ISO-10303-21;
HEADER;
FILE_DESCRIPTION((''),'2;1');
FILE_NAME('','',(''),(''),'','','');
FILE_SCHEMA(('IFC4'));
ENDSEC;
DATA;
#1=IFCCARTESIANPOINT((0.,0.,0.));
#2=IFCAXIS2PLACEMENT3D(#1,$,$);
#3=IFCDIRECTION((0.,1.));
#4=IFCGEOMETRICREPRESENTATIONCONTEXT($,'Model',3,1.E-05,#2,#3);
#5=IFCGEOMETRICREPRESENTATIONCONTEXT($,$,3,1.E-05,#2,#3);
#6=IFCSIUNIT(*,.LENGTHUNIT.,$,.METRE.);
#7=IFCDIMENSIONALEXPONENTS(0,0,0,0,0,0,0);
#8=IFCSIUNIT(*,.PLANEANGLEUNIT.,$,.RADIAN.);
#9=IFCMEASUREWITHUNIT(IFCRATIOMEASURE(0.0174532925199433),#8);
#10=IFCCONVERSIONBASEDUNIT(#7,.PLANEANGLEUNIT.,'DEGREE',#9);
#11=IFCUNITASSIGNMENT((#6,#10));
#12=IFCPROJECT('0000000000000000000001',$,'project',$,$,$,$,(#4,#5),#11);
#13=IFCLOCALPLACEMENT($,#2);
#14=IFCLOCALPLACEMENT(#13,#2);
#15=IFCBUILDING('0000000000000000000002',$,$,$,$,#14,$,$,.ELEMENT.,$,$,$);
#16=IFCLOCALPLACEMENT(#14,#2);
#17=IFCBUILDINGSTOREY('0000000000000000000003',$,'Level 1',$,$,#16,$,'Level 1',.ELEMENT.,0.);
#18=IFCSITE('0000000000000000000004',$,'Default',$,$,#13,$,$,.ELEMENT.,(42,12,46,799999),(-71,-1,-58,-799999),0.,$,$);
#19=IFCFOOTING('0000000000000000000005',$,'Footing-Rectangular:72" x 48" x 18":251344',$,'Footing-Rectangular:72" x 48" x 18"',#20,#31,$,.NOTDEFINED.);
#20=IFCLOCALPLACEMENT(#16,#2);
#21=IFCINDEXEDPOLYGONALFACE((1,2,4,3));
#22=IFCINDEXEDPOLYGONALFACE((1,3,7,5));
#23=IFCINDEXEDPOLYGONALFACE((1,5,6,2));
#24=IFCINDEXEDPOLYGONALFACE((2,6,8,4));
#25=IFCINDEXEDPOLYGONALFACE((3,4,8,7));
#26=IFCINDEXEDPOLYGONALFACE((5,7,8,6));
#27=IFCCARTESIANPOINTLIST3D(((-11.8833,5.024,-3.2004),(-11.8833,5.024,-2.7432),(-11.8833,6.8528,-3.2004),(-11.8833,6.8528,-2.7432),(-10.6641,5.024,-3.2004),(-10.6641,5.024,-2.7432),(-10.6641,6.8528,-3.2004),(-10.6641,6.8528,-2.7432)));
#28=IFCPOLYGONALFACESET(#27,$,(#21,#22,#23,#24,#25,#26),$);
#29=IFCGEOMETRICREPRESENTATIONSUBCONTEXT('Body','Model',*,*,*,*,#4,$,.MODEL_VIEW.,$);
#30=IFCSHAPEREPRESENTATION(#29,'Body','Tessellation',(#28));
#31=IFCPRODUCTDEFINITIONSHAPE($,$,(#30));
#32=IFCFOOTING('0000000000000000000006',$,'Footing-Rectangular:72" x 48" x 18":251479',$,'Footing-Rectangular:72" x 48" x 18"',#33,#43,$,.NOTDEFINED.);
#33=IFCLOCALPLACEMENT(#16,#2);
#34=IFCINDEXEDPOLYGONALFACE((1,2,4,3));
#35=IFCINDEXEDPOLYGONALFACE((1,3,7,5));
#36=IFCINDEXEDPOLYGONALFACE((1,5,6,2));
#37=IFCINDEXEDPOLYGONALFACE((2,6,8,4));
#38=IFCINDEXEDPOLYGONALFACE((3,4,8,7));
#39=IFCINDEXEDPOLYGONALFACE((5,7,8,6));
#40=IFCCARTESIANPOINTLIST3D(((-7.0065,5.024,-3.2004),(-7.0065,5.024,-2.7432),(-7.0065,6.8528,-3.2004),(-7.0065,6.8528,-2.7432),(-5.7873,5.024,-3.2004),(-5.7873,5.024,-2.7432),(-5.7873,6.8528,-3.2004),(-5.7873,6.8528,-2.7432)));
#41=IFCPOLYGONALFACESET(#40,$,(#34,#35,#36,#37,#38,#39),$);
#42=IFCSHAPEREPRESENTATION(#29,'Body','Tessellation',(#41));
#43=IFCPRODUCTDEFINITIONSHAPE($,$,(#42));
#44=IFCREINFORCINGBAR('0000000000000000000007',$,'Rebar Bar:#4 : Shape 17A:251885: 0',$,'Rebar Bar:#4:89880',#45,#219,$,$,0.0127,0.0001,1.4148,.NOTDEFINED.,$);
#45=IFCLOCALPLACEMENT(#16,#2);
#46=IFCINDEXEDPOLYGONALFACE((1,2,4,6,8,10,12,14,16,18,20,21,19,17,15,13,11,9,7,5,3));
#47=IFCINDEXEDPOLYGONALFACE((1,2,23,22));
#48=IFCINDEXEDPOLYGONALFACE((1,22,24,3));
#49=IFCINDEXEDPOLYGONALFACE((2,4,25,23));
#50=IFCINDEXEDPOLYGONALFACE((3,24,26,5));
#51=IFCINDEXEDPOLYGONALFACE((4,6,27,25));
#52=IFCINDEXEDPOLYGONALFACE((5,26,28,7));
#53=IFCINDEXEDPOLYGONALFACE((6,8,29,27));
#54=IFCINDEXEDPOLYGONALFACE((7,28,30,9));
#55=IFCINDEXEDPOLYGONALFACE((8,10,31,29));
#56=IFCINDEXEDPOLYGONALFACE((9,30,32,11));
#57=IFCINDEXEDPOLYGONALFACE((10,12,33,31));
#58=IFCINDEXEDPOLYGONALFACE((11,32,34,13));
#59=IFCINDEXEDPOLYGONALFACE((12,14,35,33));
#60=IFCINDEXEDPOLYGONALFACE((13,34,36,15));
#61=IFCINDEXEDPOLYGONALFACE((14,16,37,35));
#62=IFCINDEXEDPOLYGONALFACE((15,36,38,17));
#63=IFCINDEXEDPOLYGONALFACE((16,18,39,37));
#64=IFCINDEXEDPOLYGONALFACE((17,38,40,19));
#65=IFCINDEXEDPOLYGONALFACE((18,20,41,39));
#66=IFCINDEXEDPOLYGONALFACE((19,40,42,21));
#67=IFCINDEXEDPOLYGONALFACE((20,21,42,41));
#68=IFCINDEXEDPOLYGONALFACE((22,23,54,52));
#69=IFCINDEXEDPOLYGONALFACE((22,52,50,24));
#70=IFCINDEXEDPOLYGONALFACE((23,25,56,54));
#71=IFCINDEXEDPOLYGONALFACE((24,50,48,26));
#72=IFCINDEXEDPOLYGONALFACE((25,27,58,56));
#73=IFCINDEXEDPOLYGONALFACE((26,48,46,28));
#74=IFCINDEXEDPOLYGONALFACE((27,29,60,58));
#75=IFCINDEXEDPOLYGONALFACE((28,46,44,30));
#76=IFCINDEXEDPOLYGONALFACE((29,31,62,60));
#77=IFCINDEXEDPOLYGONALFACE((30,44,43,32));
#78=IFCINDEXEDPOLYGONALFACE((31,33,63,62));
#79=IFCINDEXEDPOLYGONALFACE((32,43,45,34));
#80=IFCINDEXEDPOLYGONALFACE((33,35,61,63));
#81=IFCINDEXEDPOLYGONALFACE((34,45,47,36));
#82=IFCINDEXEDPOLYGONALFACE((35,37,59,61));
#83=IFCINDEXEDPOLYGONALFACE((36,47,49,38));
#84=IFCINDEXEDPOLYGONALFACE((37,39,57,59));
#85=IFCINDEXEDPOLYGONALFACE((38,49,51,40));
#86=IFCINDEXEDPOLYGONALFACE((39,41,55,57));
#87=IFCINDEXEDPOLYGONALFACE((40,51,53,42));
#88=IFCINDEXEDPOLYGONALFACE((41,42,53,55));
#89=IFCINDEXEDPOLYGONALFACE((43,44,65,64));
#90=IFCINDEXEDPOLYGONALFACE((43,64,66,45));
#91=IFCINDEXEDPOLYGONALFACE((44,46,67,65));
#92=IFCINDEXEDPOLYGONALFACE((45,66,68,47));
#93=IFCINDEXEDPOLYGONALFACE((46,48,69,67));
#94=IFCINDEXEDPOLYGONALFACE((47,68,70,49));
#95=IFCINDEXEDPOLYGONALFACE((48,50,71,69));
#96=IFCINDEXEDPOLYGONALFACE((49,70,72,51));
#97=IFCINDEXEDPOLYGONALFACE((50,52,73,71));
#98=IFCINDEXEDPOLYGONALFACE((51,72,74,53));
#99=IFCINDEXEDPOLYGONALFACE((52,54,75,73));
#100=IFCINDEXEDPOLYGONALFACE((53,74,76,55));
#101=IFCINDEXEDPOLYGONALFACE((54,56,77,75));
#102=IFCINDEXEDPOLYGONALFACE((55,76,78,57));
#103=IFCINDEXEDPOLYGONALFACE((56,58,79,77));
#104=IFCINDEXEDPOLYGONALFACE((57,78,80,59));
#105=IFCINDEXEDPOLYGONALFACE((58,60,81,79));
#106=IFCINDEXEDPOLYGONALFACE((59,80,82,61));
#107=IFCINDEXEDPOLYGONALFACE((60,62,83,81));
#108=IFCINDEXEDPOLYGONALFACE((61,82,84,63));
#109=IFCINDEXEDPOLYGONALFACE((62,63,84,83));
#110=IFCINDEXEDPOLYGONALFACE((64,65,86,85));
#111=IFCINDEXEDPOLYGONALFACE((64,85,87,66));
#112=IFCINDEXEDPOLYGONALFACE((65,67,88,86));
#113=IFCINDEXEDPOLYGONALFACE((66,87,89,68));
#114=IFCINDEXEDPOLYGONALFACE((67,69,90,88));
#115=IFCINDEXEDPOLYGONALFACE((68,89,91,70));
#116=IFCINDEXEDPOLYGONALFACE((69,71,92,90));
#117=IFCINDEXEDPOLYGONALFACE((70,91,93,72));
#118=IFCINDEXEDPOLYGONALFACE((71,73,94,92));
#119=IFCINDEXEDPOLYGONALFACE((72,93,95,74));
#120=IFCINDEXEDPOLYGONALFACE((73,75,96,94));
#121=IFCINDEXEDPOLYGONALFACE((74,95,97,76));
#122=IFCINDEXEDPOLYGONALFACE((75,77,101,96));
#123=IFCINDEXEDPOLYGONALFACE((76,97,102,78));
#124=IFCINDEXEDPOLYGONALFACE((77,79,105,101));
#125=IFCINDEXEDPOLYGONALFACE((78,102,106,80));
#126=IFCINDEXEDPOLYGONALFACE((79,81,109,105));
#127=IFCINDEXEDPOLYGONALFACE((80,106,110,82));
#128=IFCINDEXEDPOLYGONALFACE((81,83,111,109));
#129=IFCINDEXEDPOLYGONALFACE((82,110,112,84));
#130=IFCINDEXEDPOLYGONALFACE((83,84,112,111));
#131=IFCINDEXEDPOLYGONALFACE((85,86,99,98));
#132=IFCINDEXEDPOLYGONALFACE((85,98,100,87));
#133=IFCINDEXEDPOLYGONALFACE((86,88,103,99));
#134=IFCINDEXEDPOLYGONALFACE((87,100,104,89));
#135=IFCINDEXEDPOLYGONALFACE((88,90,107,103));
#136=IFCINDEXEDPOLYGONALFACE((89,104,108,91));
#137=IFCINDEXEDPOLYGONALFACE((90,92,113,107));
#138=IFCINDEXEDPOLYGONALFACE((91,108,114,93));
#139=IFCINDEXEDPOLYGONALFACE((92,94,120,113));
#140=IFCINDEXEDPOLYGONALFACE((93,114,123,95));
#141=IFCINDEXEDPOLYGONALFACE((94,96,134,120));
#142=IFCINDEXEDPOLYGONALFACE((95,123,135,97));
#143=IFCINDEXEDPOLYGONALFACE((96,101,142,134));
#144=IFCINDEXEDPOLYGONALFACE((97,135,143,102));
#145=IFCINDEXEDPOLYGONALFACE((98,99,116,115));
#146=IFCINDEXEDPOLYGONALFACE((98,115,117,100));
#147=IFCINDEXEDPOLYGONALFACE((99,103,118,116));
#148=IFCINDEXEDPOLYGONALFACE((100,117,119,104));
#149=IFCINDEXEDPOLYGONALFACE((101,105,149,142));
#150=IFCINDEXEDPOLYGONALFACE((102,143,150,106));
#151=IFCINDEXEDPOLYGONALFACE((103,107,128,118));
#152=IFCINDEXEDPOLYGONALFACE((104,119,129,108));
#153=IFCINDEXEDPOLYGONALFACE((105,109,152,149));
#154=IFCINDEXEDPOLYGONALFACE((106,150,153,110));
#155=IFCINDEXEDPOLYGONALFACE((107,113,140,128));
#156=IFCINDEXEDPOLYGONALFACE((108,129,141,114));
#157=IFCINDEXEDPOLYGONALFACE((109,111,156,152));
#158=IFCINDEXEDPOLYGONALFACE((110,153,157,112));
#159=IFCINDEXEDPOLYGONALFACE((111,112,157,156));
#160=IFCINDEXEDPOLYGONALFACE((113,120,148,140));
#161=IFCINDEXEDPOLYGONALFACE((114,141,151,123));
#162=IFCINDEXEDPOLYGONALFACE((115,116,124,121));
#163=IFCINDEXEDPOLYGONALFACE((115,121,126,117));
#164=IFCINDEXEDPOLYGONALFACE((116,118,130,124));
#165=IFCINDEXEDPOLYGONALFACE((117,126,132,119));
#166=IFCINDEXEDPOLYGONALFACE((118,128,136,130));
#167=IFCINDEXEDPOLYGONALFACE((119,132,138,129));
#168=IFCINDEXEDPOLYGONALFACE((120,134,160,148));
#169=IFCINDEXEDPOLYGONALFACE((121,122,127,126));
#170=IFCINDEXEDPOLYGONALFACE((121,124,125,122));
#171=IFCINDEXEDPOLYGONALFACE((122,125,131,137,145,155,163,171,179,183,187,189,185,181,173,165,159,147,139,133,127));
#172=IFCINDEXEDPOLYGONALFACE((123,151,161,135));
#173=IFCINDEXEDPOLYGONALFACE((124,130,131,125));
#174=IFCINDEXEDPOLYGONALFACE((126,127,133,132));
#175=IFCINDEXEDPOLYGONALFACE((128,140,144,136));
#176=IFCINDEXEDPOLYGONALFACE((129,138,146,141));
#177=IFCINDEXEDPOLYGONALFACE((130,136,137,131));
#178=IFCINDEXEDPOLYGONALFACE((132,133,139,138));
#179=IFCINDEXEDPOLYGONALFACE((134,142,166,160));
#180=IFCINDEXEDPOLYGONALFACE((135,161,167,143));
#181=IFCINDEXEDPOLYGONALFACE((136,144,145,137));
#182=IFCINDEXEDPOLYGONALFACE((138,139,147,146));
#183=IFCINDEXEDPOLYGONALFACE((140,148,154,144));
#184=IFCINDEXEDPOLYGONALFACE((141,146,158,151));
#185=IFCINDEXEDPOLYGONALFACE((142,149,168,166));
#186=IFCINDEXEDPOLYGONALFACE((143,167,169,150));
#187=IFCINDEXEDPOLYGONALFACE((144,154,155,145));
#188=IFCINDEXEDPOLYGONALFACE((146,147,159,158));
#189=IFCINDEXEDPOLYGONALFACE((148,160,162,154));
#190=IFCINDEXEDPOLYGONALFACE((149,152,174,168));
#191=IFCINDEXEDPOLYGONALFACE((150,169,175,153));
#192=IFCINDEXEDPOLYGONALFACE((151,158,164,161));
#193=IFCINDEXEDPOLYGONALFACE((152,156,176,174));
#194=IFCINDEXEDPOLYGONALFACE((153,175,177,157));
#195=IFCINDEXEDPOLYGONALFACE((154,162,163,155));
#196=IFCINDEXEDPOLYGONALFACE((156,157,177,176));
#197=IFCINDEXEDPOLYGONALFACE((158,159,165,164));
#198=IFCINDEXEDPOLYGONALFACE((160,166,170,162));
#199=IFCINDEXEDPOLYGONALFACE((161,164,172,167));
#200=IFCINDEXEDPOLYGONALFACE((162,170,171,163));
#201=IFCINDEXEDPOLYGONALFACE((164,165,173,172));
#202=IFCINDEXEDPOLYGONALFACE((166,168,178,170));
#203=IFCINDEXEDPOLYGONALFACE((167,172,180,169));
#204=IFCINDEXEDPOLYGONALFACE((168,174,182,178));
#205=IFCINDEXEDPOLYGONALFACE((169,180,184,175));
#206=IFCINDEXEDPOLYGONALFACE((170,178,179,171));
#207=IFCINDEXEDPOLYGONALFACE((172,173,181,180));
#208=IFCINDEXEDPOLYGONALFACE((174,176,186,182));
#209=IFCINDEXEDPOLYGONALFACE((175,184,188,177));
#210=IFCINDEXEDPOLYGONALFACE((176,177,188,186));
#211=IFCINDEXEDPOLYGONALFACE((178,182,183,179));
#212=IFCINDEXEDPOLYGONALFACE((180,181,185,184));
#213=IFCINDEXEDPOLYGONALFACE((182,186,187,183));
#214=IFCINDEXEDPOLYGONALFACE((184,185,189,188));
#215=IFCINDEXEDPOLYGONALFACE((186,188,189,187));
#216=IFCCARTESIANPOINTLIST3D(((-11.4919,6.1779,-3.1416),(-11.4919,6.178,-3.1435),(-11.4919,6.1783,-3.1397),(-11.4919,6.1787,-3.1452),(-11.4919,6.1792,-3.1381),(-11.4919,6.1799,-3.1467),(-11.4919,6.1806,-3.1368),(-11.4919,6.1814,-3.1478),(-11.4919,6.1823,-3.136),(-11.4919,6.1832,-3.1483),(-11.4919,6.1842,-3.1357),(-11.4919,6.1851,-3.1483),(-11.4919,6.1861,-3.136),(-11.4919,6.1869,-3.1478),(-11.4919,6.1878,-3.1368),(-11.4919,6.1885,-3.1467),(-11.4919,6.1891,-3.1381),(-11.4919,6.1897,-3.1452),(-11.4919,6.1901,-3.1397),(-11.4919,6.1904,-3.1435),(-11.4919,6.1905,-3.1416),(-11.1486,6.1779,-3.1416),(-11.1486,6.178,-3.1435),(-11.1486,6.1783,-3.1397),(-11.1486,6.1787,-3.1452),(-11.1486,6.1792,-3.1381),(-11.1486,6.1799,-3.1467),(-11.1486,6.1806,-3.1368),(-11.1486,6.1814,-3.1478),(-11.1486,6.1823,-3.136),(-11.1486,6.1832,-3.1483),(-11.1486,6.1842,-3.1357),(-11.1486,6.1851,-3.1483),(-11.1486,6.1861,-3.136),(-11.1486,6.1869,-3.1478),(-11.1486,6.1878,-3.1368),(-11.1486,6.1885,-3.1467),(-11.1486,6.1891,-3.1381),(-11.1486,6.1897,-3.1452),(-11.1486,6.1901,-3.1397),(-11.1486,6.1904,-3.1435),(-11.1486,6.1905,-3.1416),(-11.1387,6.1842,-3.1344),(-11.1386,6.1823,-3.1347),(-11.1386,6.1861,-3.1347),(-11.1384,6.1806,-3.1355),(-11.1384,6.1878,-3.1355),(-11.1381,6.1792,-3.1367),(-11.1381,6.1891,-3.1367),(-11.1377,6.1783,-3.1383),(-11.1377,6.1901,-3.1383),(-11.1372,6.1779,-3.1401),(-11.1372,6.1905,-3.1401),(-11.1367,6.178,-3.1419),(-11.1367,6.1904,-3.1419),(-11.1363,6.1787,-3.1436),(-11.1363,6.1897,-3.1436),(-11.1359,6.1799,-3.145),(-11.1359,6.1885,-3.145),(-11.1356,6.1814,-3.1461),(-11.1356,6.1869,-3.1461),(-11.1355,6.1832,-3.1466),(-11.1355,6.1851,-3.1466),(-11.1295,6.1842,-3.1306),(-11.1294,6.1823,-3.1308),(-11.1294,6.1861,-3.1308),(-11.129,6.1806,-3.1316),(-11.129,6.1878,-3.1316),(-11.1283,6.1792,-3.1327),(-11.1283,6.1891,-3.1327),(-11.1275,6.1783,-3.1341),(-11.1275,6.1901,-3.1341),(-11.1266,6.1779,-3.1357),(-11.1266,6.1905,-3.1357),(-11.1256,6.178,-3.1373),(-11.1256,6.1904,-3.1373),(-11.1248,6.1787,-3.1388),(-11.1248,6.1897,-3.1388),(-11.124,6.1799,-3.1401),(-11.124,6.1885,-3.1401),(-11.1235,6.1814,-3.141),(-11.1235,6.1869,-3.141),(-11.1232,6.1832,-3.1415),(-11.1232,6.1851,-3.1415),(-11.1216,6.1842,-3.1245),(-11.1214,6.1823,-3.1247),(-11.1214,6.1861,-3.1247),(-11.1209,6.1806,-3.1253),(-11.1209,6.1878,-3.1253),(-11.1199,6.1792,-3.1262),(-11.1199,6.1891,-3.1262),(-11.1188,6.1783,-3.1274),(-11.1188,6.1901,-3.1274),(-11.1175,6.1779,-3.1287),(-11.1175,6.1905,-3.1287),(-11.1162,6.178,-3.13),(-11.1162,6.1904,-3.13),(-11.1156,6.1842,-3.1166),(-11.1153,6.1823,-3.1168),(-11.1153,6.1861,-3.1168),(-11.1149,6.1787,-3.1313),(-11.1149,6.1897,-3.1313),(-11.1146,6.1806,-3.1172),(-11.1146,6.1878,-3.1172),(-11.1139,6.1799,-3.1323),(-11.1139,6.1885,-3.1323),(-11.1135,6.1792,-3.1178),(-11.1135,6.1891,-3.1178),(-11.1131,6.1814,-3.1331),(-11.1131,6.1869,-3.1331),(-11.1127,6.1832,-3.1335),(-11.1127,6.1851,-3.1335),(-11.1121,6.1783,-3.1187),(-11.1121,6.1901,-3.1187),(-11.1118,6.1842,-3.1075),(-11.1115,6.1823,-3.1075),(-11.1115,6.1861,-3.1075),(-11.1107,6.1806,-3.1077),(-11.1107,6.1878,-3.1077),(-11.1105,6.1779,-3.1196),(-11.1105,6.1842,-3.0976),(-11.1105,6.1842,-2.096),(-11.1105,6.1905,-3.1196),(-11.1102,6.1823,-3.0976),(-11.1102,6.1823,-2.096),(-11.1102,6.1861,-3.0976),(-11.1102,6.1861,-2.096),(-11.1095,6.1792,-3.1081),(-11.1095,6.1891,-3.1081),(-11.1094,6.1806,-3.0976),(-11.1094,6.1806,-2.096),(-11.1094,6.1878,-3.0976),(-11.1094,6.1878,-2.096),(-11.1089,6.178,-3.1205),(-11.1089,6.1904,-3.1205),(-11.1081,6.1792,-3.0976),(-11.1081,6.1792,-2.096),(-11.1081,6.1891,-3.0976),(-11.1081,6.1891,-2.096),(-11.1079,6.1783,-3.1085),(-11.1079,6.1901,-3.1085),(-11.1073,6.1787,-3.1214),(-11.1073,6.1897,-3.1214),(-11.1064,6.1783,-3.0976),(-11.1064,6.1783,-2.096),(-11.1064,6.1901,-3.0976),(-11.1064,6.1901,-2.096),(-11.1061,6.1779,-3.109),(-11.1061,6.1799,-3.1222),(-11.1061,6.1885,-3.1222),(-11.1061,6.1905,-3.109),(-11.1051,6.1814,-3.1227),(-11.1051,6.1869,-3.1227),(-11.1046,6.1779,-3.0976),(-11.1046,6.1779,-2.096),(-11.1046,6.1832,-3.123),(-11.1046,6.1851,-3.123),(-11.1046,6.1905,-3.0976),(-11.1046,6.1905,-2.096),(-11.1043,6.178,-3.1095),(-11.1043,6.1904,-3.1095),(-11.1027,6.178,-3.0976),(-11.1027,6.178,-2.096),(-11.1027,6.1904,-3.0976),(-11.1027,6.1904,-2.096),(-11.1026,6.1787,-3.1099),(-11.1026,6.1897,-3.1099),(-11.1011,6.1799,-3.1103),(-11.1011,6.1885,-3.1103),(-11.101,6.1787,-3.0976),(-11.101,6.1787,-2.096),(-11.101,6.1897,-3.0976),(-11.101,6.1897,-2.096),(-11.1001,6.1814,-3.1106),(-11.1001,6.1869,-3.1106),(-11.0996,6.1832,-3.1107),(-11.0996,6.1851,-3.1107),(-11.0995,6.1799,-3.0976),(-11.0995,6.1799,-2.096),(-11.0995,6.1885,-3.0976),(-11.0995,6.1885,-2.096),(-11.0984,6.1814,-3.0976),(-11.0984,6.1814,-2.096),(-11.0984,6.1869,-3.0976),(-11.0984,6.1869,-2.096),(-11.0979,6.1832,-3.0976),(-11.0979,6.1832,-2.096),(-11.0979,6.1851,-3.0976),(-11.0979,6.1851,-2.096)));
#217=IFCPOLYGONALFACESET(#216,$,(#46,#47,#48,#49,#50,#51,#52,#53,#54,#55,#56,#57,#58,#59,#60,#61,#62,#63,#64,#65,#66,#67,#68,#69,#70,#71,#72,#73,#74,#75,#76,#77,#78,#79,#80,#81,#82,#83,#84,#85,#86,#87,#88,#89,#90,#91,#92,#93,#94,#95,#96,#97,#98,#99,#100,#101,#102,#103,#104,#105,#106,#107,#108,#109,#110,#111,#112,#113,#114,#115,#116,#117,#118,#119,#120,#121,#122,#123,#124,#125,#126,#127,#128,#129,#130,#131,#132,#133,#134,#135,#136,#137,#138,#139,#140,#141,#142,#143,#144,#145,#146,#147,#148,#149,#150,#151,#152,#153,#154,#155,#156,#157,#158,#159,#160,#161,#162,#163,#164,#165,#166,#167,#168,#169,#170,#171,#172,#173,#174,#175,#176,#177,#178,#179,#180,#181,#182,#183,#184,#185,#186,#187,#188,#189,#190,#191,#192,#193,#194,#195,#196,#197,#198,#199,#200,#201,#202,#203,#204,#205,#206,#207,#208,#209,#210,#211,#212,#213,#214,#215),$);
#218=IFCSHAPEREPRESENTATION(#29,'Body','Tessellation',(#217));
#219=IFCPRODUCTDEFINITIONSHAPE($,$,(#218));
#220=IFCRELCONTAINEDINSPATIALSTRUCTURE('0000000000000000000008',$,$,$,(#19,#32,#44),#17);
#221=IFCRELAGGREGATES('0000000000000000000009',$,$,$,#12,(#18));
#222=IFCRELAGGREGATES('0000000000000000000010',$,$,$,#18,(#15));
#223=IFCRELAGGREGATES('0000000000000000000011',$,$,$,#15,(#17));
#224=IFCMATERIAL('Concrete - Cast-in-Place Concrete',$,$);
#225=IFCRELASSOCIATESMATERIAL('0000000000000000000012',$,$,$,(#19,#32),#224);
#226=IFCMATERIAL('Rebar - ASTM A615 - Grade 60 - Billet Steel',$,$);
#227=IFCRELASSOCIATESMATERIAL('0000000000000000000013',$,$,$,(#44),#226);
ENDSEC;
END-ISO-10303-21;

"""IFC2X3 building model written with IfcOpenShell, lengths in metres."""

from ifc_helpers import new_model, entity, si_unit, converted_unit, direction, frame, origin, origin_2d_with_axis, place, context, subcontext, project, spatial, rectangle, extrude, material, element, save


model = new_model("IFC2X3")

# Units and contexts
model_context = context("Model", 3, precision=1e-05, world=origin(), true_north=direction((0.0, 1.0)))
context_of_model = context(None, 3, precision=1e-05, world=origin(), true_north=direction((0.0, 1.0)))
body_context = subcontext(model_context, "Body", "Model", "MODEL_VIEW")
ifc_project = project(units=[si_unit("LENGTHUNIT", "METRE"), converted_unit("PLANEANGLEUNIT", "DEGREE", entity("IfcRatioMeasure", 0.0174532925199433), si_unit("PLANEANGLEUNIT", "RADIAN"), dimensions=[0, 0, 0, 0, 0, 0, 0])], contexts=[model_context, context_of_model])

# Site, building, storey
site_placement = place(None, origin())
site = spatial("IfcSite", under=ifc_project, at=site_placement, Name="Default", CompositionType="ELEMENT", RefLatitude=(42, 12, 46, 799999), RefLongitude=(-71, -1, -58, -799999), RefElevation=0.0)
building_placement = place(site_placement, origin())
building = spatial("IfcBuilding", under=site, at=building_placement, CompositionType="ELEMENT")
storey_placement = place(building_placement, origin())
storey = spatial("IfcBuildingStorey", under=building, at=storey_placement, Name="Level 1", LongName="Level 1", CompositionType="ELEMENT", Elevation=0.0)

# Footings
ifc_material_1 = material(Name="Concrete - Cast-in-Place Concrete")
footing_1_placement = place(storey_placement, origin())
element("IfcFooting", 1, at=footing_1_placement, inside=storey, material=ifc_material_1, Name="Footing-Rectangular:72\" x 48\" x 18\":251344", ObjectType="Footing-Rectangular:72\" x 48\" x 18\"", PredefinedType="NOTDEFINED", context=body_context, shape_type="SweptSolid", body=[
    extrude(rectangle(XDim=1.2192, YDim=1.8288, at=origin_2d_with_axis()), frame((-11.2737, 5.9384, -3.2004), z_axis=(0.0, 0.0, 1.0), x_axis=(-1.0, 0.0, 0.0)), (0.0, 0.0, 1.0), 0.4572),
])
footing_2_placement = place(storey_placement, origin())
element("IfcFooting", 2, at=footing_2_placement, inside=storey, material=ifc_material_1, Name="Footing-Rectangular:72\" x 48\" x 18\":251479", ObjectType="Footing-Rectangular:72\" x 48\" x 18\"", PredefinedType="NOTDEFINED", context=body_context, shape_type="SweptSolid", body=[
    extrude(rectangle(XDim=1.2192, YDim=1.8288, at=origin_2d_with_axis()), frame((-6.3969, 5.9384, -3.2004), z_axis=(0.0, 0.0, 1.0), x_axis=(-1.0, 0.0, 0.0)), (0.0, 0.0, 1.0), 0.4572),
])

# Reinforcing bar
ifc_material_2 = material(Name="Rebar - ASTM A615 - Grade 60 - Billet Steel")
reinforcing_bar_1_placement = place(storey_placement, origin())
element("IfcReinforcingBar", 3, at=reinforcing_bar_1_placement, inside=storey, material=ifc_material_2, Name="Rebar Bar:#4 : Shape 17A:251885: 0", ObjectType="Rebar Bar:#4:89880", BarLength=1.4148, BarRole="NOTDEFINED", CrossSectionArea=0.0001, NominalDiameter=0.0127, context=body_context, shape_type="AdvancedSweptSolid", body=[
    entity("IfcSweptDiskSolid", entity("IfcCompositeCurve", [entity("IfcCompositeCurveSegment", "CONTINUOUS", True, entity("IfcPolyline", [entity("IfcCartesianPoint", [-11.4919, 6.1842, -3.142]), entity("IfcCartesianPoint", [-11.1486, 6.1842, -3.142])])), entity("IfcCompositeCurveSegment", "CONTINUOUS", True, entity("IfcTrimmedCurve", entity("IfcCircle", entity("IfcAxis2Placement3D", entity("IfcCartesianPoint", [-11.1486, 6.1842, -3.0976]), entity("IfcDirection", [0.0, -1.0, 0.0]), entity("IfcDirection", [1.0, 0.0, 0.0])), 0.0445), [entity("IfcParameterValue", 270.0)], [entity("IfcParameterValue", 360.0)], True, "PARAMETER")), entity("IfcCompositeCurveSegment", "CONTINUOUS", True, entity("IfcPolyline", [entity("IfcCartesianPoint", [-11.1041, 6.1842, -3.0976]), entity("IfcCartesianPoint", [-11.1041, 6.1842, -2.096])]))], False), 0.0063, None, 0.0, 92.0),
])

save(model, "model.ifc")
